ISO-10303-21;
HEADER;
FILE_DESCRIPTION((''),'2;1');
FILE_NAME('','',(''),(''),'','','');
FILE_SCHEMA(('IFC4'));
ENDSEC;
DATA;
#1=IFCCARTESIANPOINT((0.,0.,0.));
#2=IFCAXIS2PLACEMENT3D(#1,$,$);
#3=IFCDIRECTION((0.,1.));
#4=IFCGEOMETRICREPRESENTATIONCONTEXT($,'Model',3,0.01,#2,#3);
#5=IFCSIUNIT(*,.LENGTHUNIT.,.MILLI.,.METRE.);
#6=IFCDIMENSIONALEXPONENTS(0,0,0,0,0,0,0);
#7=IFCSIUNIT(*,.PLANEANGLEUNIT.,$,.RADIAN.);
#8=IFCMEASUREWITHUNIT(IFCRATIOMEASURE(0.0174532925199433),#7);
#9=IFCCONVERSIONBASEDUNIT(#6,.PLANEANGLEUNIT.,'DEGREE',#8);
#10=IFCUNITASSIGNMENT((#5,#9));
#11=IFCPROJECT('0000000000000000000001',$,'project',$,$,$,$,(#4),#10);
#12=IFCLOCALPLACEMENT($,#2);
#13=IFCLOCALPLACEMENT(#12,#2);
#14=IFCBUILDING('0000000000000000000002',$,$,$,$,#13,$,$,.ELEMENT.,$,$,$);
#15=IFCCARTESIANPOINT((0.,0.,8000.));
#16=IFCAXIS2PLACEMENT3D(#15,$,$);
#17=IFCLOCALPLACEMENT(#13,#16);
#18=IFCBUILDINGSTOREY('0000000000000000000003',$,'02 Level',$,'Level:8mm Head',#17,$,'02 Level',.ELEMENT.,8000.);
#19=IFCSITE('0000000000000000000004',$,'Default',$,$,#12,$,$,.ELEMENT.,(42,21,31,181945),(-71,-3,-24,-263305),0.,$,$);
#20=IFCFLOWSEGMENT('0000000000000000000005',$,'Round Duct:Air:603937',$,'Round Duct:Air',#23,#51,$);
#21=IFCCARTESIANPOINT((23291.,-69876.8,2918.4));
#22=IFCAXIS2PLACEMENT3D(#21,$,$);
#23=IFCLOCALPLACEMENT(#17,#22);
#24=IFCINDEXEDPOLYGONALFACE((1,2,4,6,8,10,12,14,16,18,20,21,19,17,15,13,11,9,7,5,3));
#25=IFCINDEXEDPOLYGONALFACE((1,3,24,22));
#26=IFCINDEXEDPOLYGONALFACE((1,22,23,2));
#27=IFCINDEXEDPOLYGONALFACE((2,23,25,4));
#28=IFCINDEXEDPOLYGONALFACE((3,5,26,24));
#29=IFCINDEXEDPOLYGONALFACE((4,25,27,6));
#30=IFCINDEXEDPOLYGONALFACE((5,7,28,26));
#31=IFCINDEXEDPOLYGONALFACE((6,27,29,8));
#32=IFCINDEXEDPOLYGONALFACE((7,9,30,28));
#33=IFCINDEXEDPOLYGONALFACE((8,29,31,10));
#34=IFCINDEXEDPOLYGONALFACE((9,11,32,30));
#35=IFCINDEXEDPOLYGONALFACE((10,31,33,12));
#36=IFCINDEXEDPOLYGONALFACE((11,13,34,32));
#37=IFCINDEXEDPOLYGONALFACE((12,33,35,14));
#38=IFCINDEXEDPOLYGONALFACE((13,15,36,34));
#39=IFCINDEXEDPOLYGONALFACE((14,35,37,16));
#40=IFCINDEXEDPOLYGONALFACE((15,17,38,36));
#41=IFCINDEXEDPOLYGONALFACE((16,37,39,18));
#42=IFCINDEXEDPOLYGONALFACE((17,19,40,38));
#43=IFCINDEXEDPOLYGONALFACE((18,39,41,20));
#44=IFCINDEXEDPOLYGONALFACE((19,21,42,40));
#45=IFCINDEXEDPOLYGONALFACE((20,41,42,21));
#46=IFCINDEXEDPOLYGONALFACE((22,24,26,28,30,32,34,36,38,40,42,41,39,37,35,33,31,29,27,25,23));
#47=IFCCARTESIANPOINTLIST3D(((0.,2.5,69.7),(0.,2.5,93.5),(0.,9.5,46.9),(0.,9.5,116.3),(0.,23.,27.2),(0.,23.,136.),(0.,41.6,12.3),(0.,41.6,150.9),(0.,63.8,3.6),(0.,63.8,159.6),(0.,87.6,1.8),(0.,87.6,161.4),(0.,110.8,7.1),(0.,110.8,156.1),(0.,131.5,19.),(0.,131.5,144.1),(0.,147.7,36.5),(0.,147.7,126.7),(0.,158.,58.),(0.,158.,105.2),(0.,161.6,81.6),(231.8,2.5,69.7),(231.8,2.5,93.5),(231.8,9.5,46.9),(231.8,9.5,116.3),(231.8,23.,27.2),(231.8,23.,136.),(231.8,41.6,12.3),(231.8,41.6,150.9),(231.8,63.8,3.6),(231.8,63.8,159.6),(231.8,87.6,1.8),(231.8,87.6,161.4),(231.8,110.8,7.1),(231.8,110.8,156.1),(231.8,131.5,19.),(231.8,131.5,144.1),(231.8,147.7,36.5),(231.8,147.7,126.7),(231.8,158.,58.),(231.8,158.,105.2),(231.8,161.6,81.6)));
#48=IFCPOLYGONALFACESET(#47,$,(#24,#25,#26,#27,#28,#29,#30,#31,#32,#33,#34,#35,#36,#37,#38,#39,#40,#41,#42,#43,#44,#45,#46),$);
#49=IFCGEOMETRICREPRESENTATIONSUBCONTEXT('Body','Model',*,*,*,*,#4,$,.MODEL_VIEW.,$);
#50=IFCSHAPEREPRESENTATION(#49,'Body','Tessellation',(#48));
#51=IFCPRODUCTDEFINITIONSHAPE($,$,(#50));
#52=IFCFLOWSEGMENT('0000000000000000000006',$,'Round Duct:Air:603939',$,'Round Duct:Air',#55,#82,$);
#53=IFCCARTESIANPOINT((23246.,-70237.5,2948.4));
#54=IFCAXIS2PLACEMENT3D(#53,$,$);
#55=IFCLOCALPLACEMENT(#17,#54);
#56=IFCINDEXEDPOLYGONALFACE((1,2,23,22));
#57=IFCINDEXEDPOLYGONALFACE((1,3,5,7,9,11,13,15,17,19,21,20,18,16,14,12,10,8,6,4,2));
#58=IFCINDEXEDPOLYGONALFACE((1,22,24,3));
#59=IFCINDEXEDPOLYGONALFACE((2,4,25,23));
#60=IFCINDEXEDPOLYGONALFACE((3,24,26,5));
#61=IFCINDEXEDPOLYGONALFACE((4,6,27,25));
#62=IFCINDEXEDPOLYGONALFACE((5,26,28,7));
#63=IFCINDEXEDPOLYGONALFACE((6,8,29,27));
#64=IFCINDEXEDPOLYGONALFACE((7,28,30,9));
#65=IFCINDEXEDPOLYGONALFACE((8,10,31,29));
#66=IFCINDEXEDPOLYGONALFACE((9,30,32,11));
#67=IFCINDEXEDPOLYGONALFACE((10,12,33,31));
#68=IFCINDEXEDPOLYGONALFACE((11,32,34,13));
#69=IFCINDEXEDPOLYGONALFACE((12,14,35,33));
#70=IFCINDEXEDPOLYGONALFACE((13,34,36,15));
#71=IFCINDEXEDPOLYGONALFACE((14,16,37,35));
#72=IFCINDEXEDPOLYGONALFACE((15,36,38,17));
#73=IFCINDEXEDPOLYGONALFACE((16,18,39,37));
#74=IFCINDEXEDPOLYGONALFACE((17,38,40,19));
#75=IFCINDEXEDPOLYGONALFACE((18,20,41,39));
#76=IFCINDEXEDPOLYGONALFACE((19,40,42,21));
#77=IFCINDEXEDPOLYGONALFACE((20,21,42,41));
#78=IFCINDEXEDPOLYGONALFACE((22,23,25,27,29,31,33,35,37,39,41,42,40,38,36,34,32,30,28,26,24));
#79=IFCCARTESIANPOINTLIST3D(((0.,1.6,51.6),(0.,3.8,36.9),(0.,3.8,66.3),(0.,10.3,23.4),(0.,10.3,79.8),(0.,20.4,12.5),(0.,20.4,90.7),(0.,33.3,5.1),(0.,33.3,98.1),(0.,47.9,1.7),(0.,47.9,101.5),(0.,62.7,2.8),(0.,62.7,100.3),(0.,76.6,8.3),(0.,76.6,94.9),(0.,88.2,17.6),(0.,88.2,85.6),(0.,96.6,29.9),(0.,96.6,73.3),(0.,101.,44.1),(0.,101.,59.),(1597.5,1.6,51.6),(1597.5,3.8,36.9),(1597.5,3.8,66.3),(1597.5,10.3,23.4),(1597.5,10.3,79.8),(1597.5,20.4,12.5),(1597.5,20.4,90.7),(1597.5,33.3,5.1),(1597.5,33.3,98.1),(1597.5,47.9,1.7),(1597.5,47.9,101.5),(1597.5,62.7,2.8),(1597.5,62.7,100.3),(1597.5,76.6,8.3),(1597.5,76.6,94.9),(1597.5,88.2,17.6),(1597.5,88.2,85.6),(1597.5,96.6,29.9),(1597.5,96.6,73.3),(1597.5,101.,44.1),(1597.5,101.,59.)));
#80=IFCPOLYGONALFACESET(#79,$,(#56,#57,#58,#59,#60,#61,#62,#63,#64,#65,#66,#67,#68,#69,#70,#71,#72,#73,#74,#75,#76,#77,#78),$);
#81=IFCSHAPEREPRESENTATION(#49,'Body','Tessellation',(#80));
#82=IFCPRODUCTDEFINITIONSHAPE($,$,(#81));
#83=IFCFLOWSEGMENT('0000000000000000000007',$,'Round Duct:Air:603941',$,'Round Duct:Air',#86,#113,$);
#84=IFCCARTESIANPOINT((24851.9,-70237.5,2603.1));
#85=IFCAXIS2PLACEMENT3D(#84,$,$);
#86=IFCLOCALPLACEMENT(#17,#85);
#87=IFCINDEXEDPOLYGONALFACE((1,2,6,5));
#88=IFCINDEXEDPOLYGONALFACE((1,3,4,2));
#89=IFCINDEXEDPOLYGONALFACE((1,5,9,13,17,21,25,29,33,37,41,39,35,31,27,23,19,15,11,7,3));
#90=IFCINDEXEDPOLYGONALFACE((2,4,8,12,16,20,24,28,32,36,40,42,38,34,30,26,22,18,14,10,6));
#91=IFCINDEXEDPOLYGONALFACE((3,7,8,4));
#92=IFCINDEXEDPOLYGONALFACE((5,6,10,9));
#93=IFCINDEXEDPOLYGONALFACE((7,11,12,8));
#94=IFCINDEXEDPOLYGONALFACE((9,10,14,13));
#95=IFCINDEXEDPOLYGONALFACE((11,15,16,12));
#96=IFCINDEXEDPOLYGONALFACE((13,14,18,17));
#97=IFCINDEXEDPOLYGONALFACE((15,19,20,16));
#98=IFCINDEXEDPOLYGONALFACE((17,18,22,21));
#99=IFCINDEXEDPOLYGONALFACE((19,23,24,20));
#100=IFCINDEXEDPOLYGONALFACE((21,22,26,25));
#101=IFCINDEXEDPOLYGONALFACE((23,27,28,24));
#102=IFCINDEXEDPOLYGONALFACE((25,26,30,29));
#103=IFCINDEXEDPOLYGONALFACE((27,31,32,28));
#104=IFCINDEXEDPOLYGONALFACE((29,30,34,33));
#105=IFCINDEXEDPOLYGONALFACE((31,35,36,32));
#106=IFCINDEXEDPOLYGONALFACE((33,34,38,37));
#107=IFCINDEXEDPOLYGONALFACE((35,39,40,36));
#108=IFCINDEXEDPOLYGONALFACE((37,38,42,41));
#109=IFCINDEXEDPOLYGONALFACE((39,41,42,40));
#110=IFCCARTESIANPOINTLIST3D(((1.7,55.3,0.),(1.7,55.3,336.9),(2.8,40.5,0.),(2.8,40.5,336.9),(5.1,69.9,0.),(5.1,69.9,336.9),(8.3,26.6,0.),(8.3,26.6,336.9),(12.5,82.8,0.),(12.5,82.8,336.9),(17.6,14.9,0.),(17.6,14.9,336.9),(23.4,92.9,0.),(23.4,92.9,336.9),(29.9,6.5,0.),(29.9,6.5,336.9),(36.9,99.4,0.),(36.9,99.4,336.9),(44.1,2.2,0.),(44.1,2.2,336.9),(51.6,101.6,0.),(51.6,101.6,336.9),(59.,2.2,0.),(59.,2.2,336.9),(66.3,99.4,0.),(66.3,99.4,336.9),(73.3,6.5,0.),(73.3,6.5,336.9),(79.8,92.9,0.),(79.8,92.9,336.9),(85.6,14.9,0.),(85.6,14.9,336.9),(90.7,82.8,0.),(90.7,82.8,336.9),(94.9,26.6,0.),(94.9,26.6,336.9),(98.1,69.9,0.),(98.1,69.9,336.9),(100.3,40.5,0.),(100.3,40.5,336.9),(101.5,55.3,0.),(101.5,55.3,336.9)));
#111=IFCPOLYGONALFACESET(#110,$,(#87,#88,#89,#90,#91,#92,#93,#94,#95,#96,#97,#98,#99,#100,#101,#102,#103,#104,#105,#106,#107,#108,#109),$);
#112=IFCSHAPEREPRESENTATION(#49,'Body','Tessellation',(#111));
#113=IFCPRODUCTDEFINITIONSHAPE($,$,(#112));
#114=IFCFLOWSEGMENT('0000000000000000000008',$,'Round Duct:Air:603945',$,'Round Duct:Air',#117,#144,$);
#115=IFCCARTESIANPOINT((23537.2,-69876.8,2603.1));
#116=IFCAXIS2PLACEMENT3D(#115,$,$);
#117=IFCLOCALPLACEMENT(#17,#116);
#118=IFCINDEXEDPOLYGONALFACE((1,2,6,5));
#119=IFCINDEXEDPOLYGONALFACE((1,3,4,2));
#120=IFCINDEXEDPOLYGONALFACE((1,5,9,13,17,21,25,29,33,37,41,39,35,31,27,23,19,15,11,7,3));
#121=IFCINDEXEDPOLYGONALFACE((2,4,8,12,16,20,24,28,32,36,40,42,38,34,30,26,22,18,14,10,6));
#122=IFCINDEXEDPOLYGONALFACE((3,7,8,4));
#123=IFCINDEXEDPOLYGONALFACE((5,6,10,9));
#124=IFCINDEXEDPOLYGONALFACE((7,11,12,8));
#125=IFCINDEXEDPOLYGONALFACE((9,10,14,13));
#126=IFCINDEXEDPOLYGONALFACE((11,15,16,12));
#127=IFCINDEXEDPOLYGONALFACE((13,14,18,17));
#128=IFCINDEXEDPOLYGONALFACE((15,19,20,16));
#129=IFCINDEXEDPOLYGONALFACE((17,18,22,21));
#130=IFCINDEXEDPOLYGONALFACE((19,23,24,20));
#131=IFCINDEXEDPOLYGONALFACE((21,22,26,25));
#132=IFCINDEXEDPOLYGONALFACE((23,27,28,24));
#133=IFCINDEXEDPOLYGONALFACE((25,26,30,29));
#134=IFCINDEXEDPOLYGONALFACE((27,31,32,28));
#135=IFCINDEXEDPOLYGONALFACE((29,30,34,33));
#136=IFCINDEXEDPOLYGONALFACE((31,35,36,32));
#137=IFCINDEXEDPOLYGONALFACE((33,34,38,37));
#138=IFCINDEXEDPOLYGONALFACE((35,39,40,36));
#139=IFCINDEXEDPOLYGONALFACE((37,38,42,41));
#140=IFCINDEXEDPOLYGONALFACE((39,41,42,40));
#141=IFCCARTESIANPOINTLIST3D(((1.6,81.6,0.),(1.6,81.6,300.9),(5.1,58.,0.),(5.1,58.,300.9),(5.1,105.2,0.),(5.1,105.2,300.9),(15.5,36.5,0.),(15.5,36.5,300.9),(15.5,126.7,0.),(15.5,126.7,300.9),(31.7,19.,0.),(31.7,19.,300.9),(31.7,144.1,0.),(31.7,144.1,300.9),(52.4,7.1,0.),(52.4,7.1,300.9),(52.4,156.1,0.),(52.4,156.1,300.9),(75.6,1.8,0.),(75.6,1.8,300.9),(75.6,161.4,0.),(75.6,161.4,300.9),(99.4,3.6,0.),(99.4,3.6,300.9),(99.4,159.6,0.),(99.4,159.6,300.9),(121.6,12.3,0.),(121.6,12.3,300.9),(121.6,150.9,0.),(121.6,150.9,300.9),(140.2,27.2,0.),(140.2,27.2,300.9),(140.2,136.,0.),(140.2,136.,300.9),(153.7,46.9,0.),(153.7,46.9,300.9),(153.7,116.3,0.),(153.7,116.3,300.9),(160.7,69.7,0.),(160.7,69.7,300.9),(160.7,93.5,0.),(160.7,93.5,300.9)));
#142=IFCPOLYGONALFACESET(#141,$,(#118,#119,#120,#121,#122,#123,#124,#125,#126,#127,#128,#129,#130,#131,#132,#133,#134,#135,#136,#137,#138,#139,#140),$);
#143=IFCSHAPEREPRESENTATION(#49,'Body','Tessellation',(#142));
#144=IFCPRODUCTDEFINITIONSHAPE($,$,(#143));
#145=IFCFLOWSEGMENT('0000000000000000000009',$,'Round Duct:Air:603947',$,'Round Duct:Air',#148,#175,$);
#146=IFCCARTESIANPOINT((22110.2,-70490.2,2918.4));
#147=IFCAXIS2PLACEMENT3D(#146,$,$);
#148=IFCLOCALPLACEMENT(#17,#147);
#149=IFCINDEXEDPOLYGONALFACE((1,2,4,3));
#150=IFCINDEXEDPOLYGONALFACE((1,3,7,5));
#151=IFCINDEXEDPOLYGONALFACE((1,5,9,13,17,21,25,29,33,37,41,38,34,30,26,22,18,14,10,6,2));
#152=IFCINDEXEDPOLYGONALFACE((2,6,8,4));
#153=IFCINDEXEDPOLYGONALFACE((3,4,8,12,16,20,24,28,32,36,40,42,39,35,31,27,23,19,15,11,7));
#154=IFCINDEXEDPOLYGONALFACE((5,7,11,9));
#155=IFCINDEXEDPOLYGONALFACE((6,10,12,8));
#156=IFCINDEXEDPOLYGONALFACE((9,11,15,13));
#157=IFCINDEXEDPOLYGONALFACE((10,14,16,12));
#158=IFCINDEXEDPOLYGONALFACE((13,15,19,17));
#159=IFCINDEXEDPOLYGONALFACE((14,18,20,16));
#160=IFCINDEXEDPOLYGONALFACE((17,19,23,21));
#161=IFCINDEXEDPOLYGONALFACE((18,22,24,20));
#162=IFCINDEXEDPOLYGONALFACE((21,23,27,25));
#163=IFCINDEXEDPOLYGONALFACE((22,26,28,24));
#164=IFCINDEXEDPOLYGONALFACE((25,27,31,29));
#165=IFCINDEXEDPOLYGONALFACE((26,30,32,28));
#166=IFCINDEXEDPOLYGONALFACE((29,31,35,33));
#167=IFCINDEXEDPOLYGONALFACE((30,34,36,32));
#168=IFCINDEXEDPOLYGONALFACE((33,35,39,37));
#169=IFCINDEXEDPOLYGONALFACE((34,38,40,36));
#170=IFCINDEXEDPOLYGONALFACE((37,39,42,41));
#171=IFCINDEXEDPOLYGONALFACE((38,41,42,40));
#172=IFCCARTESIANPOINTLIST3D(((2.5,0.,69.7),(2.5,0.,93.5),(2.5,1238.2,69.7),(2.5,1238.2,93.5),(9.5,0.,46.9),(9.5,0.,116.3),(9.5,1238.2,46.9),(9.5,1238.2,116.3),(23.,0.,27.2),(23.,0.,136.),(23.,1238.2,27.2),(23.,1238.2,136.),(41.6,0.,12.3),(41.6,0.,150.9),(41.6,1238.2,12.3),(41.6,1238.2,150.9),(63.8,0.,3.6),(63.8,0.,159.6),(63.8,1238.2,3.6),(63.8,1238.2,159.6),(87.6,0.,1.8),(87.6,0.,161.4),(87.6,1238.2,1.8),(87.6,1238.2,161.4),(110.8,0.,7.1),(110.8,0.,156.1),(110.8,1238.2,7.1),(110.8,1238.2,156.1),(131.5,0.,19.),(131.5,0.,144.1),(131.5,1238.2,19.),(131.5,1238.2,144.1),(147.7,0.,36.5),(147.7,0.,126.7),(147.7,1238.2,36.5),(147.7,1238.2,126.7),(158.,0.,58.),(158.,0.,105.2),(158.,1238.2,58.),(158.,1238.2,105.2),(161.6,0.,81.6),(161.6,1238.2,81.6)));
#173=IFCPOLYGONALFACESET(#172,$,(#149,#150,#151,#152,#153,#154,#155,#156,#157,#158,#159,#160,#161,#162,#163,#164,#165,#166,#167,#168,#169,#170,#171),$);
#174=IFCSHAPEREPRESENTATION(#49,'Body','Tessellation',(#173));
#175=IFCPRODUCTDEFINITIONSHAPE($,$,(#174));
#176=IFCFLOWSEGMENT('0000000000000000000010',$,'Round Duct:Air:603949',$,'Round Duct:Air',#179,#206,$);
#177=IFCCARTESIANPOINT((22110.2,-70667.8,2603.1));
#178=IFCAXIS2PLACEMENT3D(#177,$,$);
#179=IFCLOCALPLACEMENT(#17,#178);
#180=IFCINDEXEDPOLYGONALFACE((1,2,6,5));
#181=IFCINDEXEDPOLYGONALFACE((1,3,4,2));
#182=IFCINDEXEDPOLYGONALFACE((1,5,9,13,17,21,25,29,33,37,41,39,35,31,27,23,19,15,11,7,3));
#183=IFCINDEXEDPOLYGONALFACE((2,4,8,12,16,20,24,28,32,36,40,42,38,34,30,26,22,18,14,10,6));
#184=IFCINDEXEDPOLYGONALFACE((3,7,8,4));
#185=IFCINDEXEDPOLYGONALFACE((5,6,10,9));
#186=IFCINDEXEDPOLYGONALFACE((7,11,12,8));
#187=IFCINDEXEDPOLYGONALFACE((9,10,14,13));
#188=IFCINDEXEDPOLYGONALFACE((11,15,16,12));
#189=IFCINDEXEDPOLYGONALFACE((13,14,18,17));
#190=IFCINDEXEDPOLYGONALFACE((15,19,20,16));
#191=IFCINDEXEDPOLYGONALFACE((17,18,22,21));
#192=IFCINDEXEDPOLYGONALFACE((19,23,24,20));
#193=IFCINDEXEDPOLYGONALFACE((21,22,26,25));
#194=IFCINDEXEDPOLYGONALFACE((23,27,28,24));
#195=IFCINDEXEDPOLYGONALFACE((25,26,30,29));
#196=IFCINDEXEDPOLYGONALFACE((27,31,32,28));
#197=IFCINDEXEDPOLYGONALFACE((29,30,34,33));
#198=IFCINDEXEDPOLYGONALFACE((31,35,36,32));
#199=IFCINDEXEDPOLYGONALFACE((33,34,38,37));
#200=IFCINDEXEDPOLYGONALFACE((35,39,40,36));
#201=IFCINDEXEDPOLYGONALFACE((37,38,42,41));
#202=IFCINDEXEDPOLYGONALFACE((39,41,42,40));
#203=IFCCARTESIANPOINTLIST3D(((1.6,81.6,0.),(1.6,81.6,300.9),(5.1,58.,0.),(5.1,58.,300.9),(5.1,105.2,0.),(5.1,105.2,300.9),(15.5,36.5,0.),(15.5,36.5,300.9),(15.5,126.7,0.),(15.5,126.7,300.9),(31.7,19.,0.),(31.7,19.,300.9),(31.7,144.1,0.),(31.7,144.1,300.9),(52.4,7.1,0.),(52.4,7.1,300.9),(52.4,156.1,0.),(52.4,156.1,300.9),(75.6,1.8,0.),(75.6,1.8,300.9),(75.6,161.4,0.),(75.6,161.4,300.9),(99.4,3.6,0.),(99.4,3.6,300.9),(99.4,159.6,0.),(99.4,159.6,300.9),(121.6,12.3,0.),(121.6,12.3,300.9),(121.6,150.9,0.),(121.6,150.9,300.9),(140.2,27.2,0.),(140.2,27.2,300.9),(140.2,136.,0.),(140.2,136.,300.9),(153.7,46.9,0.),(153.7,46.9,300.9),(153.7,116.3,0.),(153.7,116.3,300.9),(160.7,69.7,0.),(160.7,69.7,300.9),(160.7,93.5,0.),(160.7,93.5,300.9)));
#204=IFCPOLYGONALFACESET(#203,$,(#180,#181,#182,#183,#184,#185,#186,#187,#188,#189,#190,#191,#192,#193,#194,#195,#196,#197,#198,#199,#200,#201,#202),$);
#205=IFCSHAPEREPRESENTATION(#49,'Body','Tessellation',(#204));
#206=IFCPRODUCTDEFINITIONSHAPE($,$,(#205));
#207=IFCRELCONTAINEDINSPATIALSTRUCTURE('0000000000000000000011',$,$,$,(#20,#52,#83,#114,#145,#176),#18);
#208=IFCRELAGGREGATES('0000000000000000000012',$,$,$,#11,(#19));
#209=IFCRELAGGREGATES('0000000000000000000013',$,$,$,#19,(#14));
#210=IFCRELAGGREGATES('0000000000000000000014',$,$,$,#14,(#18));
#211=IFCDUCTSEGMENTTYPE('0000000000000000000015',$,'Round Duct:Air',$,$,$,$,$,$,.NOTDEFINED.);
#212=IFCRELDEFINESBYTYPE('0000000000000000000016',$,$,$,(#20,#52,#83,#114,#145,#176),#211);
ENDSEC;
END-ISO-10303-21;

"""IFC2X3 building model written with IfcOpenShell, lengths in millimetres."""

from ifc_helpers import new_model, entity, si_unit, converted_unit, direction, frame, origin, origin_2d_with_axis, place, context, subcontext, project, spatial, circle, extrude, type_object, element, save


model = new_model("IFC2X3")

# Units and contexts
model_context = context("Model", 3, precision=0.01, world=origin(), true_north=direction((0.0, 1.0)))
body_context = subcontext(model_context, "Body", "Model", "MODEL_VIEW")
ifc_project = project(units=[si_unit("LENGTHUNIT", "METRE", prefix="MILLI"), converted_unit("PLANEANGLEUNIT", "DEGREE", entity("IfcRatioMeasure", 0.0174532925199433), si_unit("PLANEANGLEUNIT", "RADIAN"), dimensions=[0, 0, 0, 0, 0, 0, 0])], contexts=[model_context])

# Site, building, storey
site_placement = place(None, origin())
site = spatial("IfcSite", under=ifc_project, at=site_placement, Name="Default", CompositionType="ELEMENT", RefLatitude=(42, 21, 31, 181945), RefLongitude=(-71, -3, -24, -263305), RefElevation=0.0)
building_placement = place(site_placement, origin())
building = spatial("IfcBuilding", under=site, at=building_placement, CompositionType="ELEMENT")
storey_placement = place(building_placement, frame((0.0, 0.0, 8000.0)))
storey = spatial("IfcBuildingStorey", under=building, at=storey_placement, Name="02 Level", ObjectType="Level:8mm Head", LongName="02 Level", CompositionType="ELEMENT", Elevation=8000.0)

# Flow segments
duct_segment_type_1 = type_object("IfcDuctSegmentType", Name="Round Duct:Air", PredefinedType="NOTDEFINED")
flow_segment_1_placement = place(storey_placement, frame((23291.0, -69876.8, 2918.4)))
element("IfcFlowSegment", 1, at=flow_segment_1_placement, inside=storey, type_object=duct_segment_type_1, Name="Round Duct:Air:603937", ObjectType="Round Duct:Air", context=body_context, shape_type="SweptSolid", body=[
    extrude(circle(Radius=80.0, at=origin_2d_with_axis()), frame((0.0, 81.6, 81.6), z_axis=(1.0, 0.0, 0.0), x_axis=(0.0, 1.0, 0.0)), (0.0, 0.0, 1.0), 231.8),
])
flow_segment_2_placement = place(storey_placement, frame((23246.0, -70237.5, 2948.4)))
element("IfcFlowSegment", 2, at=flow_segment_2_placement, inside=storey, type_object=duct_segment_type_1, Name="Round Duct:Air:603939", ObjectType="Round Duct:Air", context=body_context, shape_type="SweptSolid", body=[
    extrude(circle(Radius=50.0, at=origin_2d_with_axis()), frame((0.0, 51.6, 51.6), z_axis=(1.0, 0.0, 0.0), x_axis=(0.0, -1.0, 0.0)), (0.0, 0.0, 1.0), 1597.5),
])
flow_segment_3_placement = place(storey_placement, frame((24851.9, -70237.5, 2603.1)))
element("IfcFlowSegment", 3, at=flow_segment_3_placement, inside=storey, type_object=duct_segment_type_1, Name="Round Duct:Air:603941", ObjectType="Round Duct:Air", context=body_context, shape_type="SweptSolid", body=[
    extrude(circle(Radius=50.0, at=origin_2d_with_axis()), frame((51.6, 51.6, 0.0), z_axis=(0.0, 0.0, 1.0), x_axis=(0.0, 1.0, 0.0)), (0.0, 0.0, 1.0), 336.9),
])
flow_segment_4_placement = place(storey_placement, frame((23537.2, -69876.8, 2603.1)))
element("IfcFlowSegment", 4, at=flow_segment_4_placement, inside=storey, type_object=duct_segment_type_1, Name="Round Duct:Air:603945", ObjectType="Round Duct:Air", context=body_context, shape_type="SweptSolid", body=[
    extrude(circle(Radius=80.0, at=origin_2d_with_axis()), frame((81.6, 81.6, 0.0), z_axis=(0.0, 0.0, 1.0), x_axis=(-1.0, 0.0, 0.0)), (0.0, 0.0, 1.0), 300.9),
])
flow_segment_5_placement = place(storey_placement, frame((22110.2, -70490.2, 2918.4)))
element("IfcFlowSegment", 5, at=flow_segment_5_placement, inside=storey, type_object=duct_segment_type_1, Name="Round Duct:Air:603947", ObjectType="Round Duct:Air", context=body_context, shape_type="SweptSolid", body=[
    extrude(circle(Radius=80.0, at=origin_2d_with_axis()), frame((81.6, 0.0, 81.6), z_axis=(0.0, 1.0, 0.0), x_axis=(1.0, 0.0, 0.0)), (0.0, 0.0, 1.0), 1238.2),
])
flow_segment_6_placement = place(storey_placement, frame((22110.2, -70667.8, 2603.1)))
element("IfcFlowSegment", 6, at=flow_segment_6_placement, inside=storey, type_object=duct_segment_type_1, Name="Round Duct:Air:603949", ObjectType="Round Duct:Air", context=body_context, shape_type="SweptSolid", body=[
    extrude(circle(Radius=80.0, at=origin_2d_with_axis()), frame((81.6, 81.6, 0.0), z_axis=(0.0, 0.0, 1.0), x_axis=(-1.0, 0.0, 0.0)), (0.0, 0.0, 1.0), 300.9),
])

save(model, "model.ifc")
